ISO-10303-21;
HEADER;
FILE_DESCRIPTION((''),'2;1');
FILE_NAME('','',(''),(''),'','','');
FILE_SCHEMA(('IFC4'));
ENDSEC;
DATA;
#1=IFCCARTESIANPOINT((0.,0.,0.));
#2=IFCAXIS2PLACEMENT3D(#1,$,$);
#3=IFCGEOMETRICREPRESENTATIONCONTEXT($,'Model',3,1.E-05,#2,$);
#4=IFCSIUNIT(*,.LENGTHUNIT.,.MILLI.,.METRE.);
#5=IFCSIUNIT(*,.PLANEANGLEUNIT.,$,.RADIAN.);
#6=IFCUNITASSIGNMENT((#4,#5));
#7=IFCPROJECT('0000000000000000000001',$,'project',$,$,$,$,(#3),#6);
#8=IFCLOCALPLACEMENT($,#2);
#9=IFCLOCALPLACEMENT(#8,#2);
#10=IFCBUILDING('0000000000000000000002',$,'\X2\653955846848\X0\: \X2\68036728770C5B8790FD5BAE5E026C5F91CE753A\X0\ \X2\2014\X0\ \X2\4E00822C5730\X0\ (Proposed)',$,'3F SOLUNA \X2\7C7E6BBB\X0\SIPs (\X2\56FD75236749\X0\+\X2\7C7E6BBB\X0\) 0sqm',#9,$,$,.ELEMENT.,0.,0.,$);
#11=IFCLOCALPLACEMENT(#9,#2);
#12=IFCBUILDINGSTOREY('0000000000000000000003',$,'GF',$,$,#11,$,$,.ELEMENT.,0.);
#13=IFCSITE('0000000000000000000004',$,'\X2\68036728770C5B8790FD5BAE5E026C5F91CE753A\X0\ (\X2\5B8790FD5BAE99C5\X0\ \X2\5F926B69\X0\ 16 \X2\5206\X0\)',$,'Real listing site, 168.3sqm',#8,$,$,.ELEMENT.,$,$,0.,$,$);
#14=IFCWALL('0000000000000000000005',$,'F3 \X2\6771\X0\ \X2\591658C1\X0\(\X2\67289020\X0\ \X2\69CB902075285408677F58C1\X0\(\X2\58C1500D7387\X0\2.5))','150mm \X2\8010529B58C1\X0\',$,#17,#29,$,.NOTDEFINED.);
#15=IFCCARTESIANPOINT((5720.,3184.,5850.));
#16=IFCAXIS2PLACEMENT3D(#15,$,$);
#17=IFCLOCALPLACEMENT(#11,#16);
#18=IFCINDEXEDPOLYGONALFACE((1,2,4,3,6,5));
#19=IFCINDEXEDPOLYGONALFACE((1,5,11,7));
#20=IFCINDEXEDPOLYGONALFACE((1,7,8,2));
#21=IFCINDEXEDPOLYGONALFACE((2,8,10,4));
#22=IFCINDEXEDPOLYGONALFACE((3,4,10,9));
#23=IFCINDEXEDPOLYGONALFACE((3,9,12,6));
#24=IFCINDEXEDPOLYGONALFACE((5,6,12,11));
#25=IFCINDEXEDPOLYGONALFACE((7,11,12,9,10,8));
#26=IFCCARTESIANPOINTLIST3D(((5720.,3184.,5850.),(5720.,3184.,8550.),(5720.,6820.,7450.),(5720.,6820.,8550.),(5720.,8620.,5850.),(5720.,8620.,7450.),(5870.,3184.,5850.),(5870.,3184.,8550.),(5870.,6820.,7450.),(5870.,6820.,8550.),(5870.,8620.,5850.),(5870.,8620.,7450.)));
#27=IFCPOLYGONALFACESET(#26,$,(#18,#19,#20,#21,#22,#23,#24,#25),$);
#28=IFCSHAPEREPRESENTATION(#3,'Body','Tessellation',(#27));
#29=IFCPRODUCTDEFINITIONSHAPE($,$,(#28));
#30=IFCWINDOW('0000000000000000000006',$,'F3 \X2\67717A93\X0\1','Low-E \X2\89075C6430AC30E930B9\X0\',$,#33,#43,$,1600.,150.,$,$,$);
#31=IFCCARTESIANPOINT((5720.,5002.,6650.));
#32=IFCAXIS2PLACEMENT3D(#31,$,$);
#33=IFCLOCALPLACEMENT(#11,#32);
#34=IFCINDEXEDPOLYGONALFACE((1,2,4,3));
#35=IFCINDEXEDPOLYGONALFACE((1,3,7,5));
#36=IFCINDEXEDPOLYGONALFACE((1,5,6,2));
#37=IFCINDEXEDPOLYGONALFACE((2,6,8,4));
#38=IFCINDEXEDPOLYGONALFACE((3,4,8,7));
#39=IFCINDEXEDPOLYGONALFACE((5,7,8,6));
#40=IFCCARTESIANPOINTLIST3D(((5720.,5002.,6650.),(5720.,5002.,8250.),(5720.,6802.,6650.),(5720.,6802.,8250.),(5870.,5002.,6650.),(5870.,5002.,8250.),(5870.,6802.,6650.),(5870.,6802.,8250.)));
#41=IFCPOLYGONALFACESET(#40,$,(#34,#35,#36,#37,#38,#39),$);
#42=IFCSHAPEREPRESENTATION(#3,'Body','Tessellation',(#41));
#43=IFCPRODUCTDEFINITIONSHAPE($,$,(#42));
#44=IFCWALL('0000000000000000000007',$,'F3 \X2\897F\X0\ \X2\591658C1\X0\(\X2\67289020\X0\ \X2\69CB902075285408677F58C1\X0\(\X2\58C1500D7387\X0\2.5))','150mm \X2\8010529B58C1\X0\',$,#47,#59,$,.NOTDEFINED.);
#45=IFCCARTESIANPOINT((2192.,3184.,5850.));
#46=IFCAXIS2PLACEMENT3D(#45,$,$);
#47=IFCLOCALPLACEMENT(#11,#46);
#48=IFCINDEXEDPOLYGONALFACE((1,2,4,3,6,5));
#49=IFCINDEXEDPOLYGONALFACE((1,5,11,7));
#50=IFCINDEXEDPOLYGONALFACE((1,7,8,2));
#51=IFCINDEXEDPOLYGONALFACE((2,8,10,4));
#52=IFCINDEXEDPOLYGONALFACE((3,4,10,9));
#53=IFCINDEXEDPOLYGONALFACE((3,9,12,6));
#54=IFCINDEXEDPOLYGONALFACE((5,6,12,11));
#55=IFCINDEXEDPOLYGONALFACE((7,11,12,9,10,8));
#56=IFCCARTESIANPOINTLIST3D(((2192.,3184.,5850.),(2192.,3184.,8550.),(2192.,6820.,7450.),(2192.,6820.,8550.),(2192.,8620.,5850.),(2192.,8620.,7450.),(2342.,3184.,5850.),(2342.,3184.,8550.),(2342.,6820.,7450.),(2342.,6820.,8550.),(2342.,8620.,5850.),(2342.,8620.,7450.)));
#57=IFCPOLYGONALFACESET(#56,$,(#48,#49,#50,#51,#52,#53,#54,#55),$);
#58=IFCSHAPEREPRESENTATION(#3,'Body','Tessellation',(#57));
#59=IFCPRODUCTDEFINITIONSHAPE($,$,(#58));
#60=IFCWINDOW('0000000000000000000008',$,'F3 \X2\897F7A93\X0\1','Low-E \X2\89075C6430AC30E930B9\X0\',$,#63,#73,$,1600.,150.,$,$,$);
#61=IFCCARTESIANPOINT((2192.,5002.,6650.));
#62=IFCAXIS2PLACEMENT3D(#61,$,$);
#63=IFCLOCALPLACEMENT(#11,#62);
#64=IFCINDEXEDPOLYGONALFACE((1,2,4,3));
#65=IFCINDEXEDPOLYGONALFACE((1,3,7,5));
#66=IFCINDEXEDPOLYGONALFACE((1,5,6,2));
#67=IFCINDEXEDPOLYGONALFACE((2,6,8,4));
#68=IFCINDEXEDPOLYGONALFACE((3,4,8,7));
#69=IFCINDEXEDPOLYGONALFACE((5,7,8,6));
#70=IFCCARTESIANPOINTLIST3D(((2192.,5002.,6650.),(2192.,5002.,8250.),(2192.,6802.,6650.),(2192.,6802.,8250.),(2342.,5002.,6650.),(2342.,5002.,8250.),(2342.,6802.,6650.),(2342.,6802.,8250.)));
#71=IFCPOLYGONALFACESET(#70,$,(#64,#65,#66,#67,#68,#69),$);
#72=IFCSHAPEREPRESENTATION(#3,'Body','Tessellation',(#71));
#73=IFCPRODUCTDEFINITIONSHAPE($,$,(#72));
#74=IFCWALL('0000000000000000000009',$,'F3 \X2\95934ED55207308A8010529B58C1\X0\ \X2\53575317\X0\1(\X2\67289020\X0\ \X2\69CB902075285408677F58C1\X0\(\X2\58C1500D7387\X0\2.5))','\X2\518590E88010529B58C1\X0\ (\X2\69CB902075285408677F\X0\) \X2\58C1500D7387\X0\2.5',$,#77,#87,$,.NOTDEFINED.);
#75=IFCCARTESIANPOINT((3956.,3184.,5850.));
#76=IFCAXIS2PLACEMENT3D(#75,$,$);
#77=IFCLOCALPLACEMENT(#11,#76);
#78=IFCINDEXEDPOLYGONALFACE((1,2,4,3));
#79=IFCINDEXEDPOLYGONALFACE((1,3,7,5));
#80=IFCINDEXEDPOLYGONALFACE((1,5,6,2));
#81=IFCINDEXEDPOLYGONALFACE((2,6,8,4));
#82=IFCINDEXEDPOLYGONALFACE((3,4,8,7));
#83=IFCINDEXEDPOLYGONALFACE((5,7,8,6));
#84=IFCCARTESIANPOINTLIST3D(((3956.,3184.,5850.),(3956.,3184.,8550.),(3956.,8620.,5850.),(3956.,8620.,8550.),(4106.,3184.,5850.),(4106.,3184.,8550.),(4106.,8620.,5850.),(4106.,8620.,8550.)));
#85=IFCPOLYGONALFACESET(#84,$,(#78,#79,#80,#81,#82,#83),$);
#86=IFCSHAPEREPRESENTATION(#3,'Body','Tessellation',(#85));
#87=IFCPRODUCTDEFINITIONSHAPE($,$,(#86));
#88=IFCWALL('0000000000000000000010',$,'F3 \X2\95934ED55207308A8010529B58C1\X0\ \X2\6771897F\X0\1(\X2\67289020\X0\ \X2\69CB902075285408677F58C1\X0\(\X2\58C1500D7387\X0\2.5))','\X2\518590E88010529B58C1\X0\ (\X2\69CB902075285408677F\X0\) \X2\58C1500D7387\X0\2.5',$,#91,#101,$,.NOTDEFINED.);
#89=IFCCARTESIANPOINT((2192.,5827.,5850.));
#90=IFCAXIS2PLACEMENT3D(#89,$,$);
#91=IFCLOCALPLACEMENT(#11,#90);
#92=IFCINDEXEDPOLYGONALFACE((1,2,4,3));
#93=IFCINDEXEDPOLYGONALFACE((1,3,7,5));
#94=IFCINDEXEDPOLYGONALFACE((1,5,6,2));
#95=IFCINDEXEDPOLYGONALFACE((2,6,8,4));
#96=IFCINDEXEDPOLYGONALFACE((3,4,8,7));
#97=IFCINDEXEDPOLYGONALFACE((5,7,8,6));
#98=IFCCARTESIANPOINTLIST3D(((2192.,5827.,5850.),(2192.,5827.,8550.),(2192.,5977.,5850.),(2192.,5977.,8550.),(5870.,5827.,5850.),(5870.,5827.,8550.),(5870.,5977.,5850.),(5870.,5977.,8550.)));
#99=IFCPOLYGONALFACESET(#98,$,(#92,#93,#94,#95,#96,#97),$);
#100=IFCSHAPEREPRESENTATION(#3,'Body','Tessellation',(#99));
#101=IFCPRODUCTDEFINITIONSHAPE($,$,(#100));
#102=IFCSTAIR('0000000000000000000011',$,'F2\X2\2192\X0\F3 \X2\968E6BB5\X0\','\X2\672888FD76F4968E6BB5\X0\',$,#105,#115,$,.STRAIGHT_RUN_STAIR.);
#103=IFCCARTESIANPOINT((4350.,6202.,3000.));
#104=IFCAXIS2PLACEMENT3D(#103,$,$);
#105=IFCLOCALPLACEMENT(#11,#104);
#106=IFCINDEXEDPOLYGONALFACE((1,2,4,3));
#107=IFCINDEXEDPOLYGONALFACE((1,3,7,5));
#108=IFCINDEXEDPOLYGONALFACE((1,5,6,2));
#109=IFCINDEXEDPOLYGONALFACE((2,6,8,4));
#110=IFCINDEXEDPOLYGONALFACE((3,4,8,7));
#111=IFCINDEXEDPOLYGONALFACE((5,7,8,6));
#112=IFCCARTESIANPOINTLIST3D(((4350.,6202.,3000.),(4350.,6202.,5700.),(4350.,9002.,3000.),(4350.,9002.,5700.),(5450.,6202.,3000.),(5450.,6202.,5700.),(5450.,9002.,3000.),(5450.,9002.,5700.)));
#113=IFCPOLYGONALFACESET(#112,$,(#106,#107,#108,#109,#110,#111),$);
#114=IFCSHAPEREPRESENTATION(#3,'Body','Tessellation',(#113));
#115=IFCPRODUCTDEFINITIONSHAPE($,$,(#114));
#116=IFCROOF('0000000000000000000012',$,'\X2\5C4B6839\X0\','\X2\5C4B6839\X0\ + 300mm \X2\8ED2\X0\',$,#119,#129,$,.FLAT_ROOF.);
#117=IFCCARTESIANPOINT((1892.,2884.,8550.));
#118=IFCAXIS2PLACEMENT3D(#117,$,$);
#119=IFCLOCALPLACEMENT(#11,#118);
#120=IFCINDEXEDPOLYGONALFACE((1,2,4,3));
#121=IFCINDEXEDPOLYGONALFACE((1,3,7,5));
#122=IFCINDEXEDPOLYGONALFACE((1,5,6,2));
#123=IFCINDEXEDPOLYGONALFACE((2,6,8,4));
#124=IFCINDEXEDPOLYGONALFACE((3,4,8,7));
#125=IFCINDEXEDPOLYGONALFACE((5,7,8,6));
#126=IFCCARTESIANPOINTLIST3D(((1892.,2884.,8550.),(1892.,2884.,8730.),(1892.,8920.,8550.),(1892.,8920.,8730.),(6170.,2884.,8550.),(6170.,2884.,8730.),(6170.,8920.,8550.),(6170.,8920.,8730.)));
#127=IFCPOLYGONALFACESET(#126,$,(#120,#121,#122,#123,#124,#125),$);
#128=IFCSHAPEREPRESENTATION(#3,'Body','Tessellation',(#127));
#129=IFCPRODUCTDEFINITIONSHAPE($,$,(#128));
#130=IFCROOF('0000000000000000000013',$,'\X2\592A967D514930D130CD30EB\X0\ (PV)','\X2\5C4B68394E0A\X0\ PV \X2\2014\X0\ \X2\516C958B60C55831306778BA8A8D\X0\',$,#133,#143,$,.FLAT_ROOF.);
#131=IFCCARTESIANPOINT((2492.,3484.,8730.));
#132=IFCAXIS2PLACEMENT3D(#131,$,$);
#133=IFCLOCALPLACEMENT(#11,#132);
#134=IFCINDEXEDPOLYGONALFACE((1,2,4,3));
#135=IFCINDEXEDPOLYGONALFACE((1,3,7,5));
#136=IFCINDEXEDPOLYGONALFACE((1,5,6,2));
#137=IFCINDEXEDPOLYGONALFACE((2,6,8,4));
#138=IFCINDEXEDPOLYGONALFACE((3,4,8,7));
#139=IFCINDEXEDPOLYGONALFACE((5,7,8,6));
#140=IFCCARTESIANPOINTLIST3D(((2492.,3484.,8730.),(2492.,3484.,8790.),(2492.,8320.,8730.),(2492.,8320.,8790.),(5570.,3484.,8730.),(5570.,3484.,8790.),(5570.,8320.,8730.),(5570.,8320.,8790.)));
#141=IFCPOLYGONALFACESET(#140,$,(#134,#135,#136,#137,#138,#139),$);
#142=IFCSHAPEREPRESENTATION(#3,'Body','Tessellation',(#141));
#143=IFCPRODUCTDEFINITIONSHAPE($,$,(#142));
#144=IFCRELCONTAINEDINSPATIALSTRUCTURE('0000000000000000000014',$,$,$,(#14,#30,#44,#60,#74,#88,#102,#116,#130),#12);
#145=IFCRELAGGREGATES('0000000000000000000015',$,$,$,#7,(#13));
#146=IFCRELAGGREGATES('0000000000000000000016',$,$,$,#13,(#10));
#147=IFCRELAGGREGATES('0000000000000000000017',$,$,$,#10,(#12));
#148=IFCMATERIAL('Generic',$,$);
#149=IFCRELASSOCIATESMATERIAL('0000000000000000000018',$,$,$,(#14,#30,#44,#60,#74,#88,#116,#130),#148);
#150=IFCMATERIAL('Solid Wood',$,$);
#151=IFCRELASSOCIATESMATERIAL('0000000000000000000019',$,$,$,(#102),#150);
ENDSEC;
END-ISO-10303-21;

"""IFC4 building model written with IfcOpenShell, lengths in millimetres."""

from ifc_helpers import new_model, si_unit, frame, frame_2d, origin, place, context, project, spatial, rectangle, extrude, material, element, fill, save


model = new_model("IFC4")

# Units and contexts
model_context = context("Model", 3, precision=1e-05, world=origin())
ifc_project = project(units=[si_unit("LENGTHUNIT", "METRE", prefix="MILLI"), si_unit("PLANEANGLEUNIT", "RADIAN")], contexts=[model_context])

# Site, building, storey
site_placement = place(None, origin())
site = spatial("IfcSite", under=ifc_project, at=site_placement, Name="栃木県宇都宮市江野町 (宇都宮駅 徒歩 16 分)", ObjectType="Real listing site, 168.3sqm", CompositionType="ELEMENT", RefElevation=0.0)
building_placement = place(site_placement, origin())
building = spatial("IfcBuilding", under=site, at=building_placement, Name="改善案: 栃木県宇都宮市江野町 — 一般地 (Proposed)", ObjectType="3F SOLUNA 籾殻SIPs (国産杉+籾殻) 0sqm", CompositionType="ELEMENT", ElevationOfRefHeight=0.0, ElevationOfTerrain=0.0)
storey_placement = place(building_placement, origin())
storey = spatial("IfcBuildingStorey", under=building, at=storey_placement, Name="GF", CompositionType="ELEMENT", Elevation=0.0)

# Shared definitions
ifc_material_1 = material(Name="Generic")

# Walls, openings, windows
wall_1_placement = place(storey_placement, frame((5720.0, 3184.0, 5850.0)))
wall_1 = element("IfcWall", 1, at=wall_1_placement, inside=storey, material=ifc_material_1, Name="F3 東 外壁(木造 構造用合板壁(壁倍率2.5))", Description="150mm 耐力壁", PredefinedType="NOTDEFINED", context=model_context, shape_type="SweptSolid", body=[
    extrude(rectangle(XDim=150.0, YDim=5436.0, at=frame_2d((75.0, 2718.0))), frame((5720.0, 3184.0, 5850.0)), (0.0, 0.0, 1.0), 2700.0),
])
opening_1_placement = place(storey_placement, frame((5720.0, 5002.0, 6650.0)))
opening_1 = element("IfcOpeningElement", 2, at=opening_1_placement, cuts=wall_1, PredefinedType="NOTDEFINED", context=model_context, shape_type="SweptSolid", body=[
    extrude(rectangle(XDim=150.0, YDim=1800.0, at=frame_2d((75.0, 900.0))), frame((5720.0, 5002.0, 6650.0)), (0.0, 0.0, 1.0), 1600.0),
])
window_1_placement = place(storey_placement, frame((5720.0, 5002.0, 6650.0)))
window_1 = element("IfcWindow", 3, at=window_1_placement, inside=storey, material=ifc_material_1, Name="F3 東窓1", Description="Low-E 複層ガラス", OverallHeight=1600.0, OverallWidth=150.0, context=model_context, shape_type="SweptSolid", body=[
    extrude(rectangle(XDim=150.0, YDim=1800.0, at=frame_2d((75.0, 900.0))), frame((5720.0, 5002.0, 6650.0)), (0.0, 0.0, 1.0), 1600.0),
])
fill(opening_1, window_1)
wall_2_placement = place(storey_placement, frame((2192.0, 3184.0, 5850.0)))
wall_2 = element("IfcWall", 4, at=wall_2_placement, inside=storey, material=ifc_material_1, Name="F3 西 外壁(木造 構造用合板壁(壁倍率2.5))", Description="150mm 耐力壁", PredefinedType="NOTDEFINED", context=model_context, shape_type="SweptSolid", body=[
    extrude(rectangle(XDim=150.0, YDim=5436.0, at=frame_2d((75.0, 2718.0))), frame((2192.0, 3184.0, 5850.0)), (0.0, 0.0, 1.0), 2700.0),
])
opening_2_placement = place(storey_placement, frame((2192.0, 5002.0, 6650.0)))
opening_2 = element("IfcOpeningElement", 5, at=opening_2_placement, cuts=wall_2, PredefinedType="NOTDEFINED", context=model_context, shape_type="SweptSolid", body=[
    extrude(rectangle(XDim=150.0, YDim=1800.0, at=frame_2d((75.0, 900.0))), frame((2192.0, 5002.0, 6650.0)), (0.0, 0.0, 1.0), 1600.0),
])
window_2_placement = place(storey_placement, frame((2192.0, 5002.0, 6650.0)))
window_2 = element("IfcWindow", 6, at=window_2_placement, inside=storey, material=ifc_material_1, Name="F3 西窓1", Description="Low-E 複層ガラス", OverallHeight=1600.0, OverallWidth=150.0, context=model_context, shape_type="SweptSolid", body=[
    extrude(rectangle(XDim=150.0, YDim=1800.0, at=frame_2d((75.0, 900.0))), frame((2192.0, 5002.0, 6650.0)), (0.0, 0.0, 1.0), 1600.0),
])
fill(opening_2, window_2)

# Walls
wall_3_placement = place(storey_placement, frame((3956.0, 3184.0, 5850.0)))
element("IfcWall", 7, at=wall_3_placement, inside=storey, material=ifc_material_1, Name="F3 間仕切り耐力壁 南北1(木造 構造用合板壁(壁倍率2.5))", Description="内部耐力壁 (構造用合板) 壁倍率2.5", PredefinedType="NOTDEFINED", context=model_context, shape_type="SweptSolid", body=[
    extrude(rectangle(XDim=150.0, YDim=5436.0, at=frame_2d((75.0, 2718.0))), frame((3956.0, 3184.0, 5850.0)), (0.0, 0.0, 1.0), 2700.0),
])
wall_4_placement = place(storey_placement, frame((2192.0, 5827.0, 5850.0)))
element("IfcWall", 8, at=wall_4_placement, inside=storey, material=ifc_material_1, Name="F3 間仕切り耐力壁 東西1(木造 構造用合板壁(壁倍率2.5))", Description="内部耐力壁 (構造用合板) 壁倍率2.5", PredefinedType="NOTDEFINED", context=model_context, shape_type="SweptSolid", body=[
    extrude(rectangle(XDim=3678.0, YDim=150.0, at=frame_2d((1839.0, 75.0))), frame((2192.0, 5827.0, 5850.0)), (0.0, 0.0, 1.0), 2700.0),
])

# Stair
ifc_material_2 = material(Name="Solid Wood")
stair_placement = place(storey_placement, frame((4350.0, 6202.0, 3000.0)))
element("IfcStair", 9, at=stair_placement, inside=storey, material=ifc_material_2, Name="F2→F3 階段", Description="木製直階段", PredefinedType="STRAIGHT_RUN_STAIR", context=model_context, shape_type="SweptSolid", body=[
    extrude(rectangle(XDim=1100.0, YDim=2800.0, at=frame_2d((550.0, 1400.0))), frame((4350.0, 6202.0, 3000.0)), (0.0, 0.0, 1.0), 2700.0),
])

# Roofs
roof_1_placement = place(storey_placement, frame((1892.0, 2884.0, 8550.0)))
element("IfcRoof", 10, at=roof_1_placement, inside=storey, material=ifc_material_1, Name="屋根", Description="屋根 + 300mm 軒", PredefinedType="FLAT_ROOF", context=model_context, shape_type="SweptSolid", body=[
    extrude(rectangle(XDim=4278.0, YDim=6036.0, at=frame_2d((2139.0, 3018.0))), frame((1892.0, 2884.0, 8550.0)), (0.0, 0.0, 1.0), 180.0),
])
roof_2_placement = place(storey_placement, frame((2492.0, 3484.0, 8730.0)))
element("IfcRoof", 11, at=roof_2_placement, inside=storey, material=ifc_material_1, Name="太陽光パネル (PV)", Description="屋根上 PV — 公開情報で確認", PredefinedType="FLAT_ROOF", context=model_context, shape_type="SweptSolid", body=[
    extrude(rectangle(XDim=3078.0, YDim=4836.0, at=frame_2d((1539.0, 2418.0))), frame((2492.0, 3484.0, 8730.0)), (0.0, 0.0, 1.0), 60.0),
])

save(model, "model.ifc")
